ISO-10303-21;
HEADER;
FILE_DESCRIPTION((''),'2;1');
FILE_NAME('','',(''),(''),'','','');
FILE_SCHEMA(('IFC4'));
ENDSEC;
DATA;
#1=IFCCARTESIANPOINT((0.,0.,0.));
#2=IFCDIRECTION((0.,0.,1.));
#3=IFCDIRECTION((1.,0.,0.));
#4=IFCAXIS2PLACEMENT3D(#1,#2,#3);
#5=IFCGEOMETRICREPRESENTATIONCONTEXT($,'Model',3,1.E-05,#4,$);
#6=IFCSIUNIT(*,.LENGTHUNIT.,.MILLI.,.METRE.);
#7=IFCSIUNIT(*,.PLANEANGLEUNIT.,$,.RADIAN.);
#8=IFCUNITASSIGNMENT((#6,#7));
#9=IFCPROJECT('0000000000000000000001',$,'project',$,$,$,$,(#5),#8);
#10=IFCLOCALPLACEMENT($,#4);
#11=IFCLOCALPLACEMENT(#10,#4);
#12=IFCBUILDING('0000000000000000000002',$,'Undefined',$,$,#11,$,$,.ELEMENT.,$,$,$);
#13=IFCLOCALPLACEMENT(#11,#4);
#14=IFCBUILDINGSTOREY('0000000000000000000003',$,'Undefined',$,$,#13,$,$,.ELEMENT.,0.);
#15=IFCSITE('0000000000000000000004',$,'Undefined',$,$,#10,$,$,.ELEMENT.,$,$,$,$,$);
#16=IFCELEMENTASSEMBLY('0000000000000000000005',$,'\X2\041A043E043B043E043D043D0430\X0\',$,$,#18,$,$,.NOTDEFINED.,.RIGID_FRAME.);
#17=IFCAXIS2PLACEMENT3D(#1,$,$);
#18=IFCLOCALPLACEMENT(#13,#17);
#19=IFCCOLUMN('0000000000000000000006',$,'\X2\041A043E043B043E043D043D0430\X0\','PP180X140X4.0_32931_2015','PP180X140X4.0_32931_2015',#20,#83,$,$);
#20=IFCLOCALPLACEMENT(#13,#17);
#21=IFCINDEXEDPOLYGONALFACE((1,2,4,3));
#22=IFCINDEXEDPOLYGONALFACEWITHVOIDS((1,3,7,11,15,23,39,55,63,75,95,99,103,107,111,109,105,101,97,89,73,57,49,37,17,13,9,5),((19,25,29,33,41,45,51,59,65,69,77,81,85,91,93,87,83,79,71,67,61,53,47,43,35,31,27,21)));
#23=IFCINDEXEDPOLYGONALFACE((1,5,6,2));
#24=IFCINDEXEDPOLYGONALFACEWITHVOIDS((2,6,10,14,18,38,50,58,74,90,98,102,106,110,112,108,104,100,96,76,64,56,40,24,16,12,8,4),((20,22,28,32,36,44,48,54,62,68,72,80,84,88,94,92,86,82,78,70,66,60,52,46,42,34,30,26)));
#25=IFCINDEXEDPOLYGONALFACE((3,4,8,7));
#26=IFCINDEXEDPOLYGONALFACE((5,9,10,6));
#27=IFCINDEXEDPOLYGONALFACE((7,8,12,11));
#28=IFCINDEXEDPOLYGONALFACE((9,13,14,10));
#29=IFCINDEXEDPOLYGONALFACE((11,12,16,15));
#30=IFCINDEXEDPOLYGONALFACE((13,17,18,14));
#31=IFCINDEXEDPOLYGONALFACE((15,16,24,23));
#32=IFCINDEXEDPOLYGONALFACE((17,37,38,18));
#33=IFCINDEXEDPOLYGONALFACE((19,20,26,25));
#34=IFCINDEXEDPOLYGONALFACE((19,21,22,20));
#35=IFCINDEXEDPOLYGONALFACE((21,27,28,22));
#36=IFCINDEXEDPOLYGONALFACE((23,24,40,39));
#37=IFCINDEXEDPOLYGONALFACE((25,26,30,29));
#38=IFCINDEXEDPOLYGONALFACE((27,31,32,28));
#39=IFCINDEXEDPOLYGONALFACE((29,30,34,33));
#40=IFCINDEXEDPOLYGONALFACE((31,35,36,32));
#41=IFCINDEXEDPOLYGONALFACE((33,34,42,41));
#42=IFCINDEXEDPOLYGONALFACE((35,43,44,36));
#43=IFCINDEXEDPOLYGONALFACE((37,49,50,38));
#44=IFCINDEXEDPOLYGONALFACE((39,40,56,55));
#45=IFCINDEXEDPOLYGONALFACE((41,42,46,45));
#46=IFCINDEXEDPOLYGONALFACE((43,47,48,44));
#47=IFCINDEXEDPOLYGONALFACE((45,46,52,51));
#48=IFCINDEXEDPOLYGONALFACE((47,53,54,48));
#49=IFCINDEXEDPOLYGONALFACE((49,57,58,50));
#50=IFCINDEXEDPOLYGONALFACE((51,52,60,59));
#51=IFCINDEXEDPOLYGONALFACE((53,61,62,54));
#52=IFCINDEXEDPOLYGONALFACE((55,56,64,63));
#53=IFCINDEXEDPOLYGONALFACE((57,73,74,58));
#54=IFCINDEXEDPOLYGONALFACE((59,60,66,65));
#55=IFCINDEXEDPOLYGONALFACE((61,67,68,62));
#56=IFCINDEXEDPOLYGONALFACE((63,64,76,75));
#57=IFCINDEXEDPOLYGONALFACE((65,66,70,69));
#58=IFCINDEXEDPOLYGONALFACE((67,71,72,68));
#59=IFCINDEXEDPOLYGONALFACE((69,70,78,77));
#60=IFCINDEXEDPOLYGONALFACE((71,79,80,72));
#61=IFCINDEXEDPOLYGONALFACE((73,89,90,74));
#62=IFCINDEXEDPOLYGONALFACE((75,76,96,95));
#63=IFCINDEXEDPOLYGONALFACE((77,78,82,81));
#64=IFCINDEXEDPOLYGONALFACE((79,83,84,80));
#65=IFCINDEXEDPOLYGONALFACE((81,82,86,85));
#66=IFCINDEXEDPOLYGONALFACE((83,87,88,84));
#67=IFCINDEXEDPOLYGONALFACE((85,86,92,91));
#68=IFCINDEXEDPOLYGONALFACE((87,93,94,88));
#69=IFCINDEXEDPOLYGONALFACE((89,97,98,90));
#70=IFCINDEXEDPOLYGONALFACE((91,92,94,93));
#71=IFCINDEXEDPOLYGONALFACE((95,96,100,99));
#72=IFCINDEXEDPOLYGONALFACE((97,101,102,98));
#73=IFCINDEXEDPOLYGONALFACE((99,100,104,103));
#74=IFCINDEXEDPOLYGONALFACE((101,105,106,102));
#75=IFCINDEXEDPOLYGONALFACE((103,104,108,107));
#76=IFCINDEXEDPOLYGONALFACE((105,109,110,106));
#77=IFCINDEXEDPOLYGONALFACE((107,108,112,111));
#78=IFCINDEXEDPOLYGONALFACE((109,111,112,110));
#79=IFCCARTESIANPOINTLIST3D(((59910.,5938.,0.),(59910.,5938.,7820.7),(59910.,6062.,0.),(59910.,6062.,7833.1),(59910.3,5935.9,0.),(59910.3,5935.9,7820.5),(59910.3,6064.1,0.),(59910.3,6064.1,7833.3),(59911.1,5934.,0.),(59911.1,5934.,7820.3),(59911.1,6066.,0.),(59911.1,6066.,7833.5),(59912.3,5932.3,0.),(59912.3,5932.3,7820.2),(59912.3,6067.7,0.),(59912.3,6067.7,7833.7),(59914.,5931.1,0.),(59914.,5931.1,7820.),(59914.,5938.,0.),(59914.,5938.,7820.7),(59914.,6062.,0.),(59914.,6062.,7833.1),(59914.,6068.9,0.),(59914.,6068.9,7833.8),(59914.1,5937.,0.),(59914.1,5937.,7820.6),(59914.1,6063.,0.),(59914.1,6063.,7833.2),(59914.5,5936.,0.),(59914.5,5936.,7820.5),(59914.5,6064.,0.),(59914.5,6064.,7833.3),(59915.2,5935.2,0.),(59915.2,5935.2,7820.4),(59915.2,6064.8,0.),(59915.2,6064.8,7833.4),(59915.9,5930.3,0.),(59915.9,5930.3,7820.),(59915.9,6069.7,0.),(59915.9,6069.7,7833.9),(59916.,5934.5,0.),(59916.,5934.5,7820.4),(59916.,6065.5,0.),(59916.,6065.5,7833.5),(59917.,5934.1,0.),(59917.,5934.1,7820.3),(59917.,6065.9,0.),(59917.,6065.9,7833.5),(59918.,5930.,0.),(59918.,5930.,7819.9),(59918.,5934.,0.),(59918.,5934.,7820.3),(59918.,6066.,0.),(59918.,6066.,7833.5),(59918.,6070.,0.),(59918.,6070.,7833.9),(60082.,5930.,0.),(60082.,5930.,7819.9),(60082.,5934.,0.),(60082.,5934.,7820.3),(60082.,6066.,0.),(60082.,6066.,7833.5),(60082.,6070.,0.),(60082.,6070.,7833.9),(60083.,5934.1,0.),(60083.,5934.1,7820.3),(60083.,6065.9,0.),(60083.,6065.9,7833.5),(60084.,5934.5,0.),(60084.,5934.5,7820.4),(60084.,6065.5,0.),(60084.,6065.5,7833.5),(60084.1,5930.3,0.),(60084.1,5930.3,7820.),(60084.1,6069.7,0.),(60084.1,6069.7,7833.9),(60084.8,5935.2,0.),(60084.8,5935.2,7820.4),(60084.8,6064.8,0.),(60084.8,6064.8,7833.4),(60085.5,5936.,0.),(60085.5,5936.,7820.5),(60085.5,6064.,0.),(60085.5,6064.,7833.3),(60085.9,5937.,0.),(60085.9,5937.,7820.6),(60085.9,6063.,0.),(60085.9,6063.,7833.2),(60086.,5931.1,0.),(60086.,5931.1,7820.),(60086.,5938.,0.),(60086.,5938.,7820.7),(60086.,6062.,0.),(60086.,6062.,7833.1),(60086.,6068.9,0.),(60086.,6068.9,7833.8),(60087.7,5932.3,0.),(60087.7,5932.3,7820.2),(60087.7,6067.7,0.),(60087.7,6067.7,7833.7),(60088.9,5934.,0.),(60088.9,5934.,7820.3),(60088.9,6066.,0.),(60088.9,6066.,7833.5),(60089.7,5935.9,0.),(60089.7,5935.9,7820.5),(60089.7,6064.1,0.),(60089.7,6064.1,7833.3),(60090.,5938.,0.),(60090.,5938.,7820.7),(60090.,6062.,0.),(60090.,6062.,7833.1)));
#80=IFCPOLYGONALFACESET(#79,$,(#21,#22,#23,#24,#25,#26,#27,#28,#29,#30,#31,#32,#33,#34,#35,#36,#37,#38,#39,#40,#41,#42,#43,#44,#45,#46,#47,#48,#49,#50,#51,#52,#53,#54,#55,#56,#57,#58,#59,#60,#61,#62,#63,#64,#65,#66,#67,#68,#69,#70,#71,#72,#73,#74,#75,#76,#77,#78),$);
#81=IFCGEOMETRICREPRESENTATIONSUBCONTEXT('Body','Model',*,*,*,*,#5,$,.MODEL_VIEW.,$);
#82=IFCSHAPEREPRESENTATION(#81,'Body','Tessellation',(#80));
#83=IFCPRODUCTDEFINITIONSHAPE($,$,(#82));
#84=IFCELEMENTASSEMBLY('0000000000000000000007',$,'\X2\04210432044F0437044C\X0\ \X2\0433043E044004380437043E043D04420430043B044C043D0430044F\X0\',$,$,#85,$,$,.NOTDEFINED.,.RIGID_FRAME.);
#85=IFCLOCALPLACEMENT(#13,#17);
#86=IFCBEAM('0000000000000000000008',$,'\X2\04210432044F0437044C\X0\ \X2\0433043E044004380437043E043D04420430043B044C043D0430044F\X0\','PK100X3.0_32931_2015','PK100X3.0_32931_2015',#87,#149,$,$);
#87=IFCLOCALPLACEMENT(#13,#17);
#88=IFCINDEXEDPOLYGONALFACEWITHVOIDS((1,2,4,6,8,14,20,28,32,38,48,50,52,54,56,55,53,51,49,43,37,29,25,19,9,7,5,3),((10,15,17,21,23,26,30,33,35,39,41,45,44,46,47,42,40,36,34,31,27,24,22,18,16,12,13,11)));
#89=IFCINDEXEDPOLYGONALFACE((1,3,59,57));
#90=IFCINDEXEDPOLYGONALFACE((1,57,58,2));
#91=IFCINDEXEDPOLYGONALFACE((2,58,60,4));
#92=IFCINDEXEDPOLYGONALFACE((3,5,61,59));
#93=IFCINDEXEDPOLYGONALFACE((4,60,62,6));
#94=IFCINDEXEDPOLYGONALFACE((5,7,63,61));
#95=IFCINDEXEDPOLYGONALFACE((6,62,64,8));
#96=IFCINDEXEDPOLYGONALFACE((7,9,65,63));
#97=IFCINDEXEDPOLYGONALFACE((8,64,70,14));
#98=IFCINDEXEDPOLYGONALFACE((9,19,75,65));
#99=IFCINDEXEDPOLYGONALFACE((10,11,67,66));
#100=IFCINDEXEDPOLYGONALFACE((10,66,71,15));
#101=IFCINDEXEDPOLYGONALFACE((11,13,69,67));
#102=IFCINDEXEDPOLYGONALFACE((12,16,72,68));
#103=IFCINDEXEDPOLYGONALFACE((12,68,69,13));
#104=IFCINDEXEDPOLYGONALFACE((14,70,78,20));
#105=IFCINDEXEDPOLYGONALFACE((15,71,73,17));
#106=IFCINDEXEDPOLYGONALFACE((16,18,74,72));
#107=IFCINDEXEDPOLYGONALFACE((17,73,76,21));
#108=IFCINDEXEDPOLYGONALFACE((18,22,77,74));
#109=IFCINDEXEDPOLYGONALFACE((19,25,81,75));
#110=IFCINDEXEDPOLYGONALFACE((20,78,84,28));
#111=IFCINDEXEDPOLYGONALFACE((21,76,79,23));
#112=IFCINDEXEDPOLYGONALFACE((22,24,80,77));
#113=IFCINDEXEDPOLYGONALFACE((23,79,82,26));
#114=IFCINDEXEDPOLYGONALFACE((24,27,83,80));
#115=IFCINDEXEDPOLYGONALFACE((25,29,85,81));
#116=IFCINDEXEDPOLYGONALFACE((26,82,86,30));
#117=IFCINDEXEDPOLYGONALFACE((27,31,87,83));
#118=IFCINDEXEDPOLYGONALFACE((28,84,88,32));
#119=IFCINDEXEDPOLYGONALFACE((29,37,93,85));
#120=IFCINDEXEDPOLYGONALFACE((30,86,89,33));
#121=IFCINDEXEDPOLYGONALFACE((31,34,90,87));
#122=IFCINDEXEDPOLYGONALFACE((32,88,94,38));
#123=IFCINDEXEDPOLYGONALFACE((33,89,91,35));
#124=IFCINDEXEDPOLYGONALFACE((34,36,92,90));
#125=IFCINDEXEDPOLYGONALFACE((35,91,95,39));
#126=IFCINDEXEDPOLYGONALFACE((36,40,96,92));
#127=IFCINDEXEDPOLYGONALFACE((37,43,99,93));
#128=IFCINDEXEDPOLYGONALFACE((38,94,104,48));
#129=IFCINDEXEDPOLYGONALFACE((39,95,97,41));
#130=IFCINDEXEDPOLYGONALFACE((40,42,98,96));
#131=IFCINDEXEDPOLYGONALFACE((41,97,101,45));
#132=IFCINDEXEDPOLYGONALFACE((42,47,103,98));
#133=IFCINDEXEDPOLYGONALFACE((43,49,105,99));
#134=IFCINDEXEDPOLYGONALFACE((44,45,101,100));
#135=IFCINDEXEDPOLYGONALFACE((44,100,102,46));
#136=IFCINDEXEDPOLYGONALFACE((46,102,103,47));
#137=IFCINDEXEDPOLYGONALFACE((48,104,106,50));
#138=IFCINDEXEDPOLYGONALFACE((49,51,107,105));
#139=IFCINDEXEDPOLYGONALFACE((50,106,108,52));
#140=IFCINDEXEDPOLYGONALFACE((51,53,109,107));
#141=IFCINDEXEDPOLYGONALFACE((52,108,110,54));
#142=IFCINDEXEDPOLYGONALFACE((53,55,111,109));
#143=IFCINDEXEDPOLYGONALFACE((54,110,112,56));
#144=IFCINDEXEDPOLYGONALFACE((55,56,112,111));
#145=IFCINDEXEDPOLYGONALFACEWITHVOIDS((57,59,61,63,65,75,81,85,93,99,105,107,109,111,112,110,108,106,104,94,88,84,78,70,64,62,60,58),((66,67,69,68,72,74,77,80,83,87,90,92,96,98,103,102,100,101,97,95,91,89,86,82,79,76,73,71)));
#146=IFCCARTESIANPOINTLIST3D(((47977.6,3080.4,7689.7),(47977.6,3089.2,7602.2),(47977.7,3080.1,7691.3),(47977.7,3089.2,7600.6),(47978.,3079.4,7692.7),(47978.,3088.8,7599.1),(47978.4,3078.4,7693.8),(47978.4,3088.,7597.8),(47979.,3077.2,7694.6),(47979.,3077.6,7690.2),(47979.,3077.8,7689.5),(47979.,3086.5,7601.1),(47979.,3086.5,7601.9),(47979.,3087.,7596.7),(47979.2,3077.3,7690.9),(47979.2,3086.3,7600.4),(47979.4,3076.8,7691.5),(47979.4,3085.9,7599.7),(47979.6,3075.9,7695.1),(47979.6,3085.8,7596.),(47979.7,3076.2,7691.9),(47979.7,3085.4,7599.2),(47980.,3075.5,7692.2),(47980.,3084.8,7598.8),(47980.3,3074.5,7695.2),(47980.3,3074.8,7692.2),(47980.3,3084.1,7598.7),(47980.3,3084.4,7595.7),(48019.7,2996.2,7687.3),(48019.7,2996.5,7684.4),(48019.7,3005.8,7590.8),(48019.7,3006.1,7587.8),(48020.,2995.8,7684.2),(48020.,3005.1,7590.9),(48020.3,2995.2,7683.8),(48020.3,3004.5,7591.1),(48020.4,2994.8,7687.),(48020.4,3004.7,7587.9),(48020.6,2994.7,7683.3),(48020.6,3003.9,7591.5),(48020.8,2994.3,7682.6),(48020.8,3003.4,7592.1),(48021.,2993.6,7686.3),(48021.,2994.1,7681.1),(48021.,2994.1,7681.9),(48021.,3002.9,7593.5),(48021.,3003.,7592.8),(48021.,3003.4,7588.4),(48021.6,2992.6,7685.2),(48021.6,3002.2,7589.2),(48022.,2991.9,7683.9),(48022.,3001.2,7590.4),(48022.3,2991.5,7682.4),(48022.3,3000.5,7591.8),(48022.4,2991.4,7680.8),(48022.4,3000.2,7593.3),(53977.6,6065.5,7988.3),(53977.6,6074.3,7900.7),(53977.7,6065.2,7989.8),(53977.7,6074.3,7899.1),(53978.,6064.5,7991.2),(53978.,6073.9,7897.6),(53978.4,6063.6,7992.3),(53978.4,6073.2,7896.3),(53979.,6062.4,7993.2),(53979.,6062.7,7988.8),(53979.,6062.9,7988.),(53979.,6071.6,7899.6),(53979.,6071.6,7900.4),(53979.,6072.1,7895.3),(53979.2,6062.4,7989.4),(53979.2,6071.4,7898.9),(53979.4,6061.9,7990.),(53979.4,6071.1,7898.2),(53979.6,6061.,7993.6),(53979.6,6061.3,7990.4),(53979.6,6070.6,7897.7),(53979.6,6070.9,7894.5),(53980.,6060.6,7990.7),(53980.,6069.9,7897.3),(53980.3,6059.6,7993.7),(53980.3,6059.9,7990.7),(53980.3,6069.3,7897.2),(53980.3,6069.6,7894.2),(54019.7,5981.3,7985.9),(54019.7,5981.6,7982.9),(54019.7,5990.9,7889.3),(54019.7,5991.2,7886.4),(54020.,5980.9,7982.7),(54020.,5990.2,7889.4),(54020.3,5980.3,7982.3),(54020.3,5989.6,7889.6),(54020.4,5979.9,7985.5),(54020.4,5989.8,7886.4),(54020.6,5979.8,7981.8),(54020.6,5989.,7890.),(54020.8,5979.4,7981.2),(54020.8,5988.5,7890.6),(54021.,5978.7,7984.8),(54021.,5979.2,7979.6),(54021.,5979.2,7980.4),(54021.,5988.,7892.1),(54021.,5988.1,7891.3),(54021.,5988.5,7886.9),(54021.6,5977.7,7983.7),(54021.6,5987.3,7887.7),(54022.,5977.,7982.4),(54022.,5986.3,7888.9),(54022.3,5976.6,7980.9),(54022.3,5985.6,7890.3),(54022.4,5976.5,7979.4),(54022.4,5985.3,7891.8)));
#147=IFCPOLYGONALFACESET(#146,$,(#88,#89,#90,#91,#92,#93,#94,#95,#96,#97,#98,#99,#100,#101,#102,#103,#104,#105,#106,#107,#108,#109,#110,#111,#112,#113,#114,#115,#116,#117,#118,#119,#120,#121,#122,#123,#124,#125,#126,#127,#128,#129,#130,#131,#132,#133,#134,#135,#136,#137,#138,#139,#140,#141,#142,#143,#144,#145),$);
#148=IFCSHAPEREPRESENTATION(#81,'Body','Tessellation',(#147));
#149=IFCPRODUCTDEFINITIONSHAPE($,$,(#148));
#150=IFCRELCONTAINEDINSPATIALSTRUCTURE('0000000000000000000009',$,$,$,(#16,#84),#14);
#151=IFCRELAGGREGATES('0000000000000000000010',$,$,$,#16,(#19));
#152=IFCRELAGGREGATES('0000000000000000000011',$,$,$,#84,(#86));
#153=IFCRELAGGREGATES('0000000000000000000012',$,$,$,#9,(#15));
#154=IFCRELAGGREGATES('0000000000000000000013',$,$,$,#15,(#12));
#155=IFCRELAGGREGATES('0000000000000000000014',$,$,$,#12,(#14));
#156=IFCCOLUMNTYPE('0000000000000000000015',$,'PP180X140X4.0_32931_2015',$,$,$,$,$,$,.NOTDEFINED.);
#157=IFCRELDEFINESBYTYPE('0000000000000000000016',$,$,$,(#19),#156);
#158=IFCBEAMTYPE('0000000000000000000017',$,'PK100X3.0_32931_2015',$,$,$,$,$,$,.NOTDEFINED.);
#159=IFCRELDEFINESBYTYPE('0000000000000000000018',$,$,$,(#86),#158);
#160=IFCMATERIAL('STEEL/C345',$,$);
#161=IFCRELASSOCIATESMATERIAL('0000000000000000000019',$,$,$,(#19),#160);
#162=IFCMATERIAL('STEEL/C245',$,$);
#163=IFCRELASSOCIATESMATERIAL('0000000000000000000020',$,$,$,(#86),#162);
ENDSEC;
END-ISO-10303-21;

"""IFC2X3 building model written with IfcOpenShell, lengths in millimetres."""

from ifc_helpers import new_model, si_unit, frame, origin_with_axes, origin_2d_with_axis, place, context, subcontext, project, spatial, hollow_rectangle, extrude, clip, halfspace, material, type_object, element, aggregate, save


model = new_model("IFC2X3")

# Units and contexts
model_context = context("Model", 3, precision=1e-05, world=origin_with_axes())
body_context = subcontext(model_context, "Body", "Model", "MODEL_VIEW")
ifc_project = project(units=[si_unit("LENGTHUNIT", "METRE", prefix="MILLI"), si_unit("PLANEANGLEUNIT", "RADIAN")], contexts=[model_context])

# Site, building, storey
site_placement = place(None, origin_with_axes())
site = spatial("IfcSite", under=ifc_project, at=site_placement, Name="Undefined", CompositionType="ELEMENT")
building_placement = place(site_placement, origin_with_axes())
building = spatial("IfcBuilding", under=site, at=building_placement, Name="Undefined", CompositionType="ELEMENT")
storey_placement = place(building_placement, origin_with_axes())
storey = spatial("IfcBuildingStorey", under=building, at=storey_placement, Name="Undefined", CompositionType="ELEMENT", Elevation=0.0)

# Element assembly, column
assembly_1_placement = place(storey_placement, origin_with_axes())
assembly_1 = element("IfcElementAssembly", 1, at=assembly_1_placement, inside=storey, Name="Колонна", AssemblyPlace="NOTDEFINED", PredefinedType="RIGID_FRAME")
ifc_material_1 = material(Name="STEEL/C345")
column_type = type_object("IfcColumnType", Name="PP180X140X4.0_32931_2015", PredefinedType="NOTDEFINED")
column_placement = place(assembly_1_placement, frame((60000.0, 6000.0, 0.0), z_axis=(0.0, 0.0, 1.0), x_axis=(1.0, 0.0, 0.0)))
column = element("IfcColumn", 2, at=column_placement, type_object=column_type, material=ifc_material_1, Name="Колонна", Description="PP180X140X4.0_32931_2015", ObjectType="PP180X140X4.0_32931_2015", context=body_context, shape_type="Clipping", body=[
    clip(extrude(hollow_rectangle(XDim=140.0, YDim=180.0, WallThickness=4.0, InnerFilletRadius=4.0, OuterFilletRadius=8.0, at=origin_2d_with_axis()), frame((0.0, 0.0, 7834.0), z_axis=(0.0, 0.0, -1.0), x_axis=(0.0, 1.0, 0.0)), (0.0, 0.0, 1.0), 7834.0), halfspace(frame((0.0, -165.8, 7810.3), z_axis=(0.0, 0.099504, -0.995037), x_axis=(-1.0, 0.0, 0.0)), True)),
])
aggregate(assembly_1, [column])

# Element assembly, beam
ifc_material_2 = material(Name="STEEL/C245")
beam_type_1 = type_object("IfcBeamType", Name="PK100X3.0_32931_2015", PredefinedType="NOTDEFINED")
assembly_2_placement = place(storey_placement, origin_with_axes())
assembly_2 = element("IfcElementAssembly", 3, at=assembly_2_placement, inside=storey, Name="Связь горизонтальная", AssemblyPlace="NOTDEFINED", PredefinedType="RIGID_FRAME")
beam_1_placement = place(assembly_2_placement, frame((54000.0, 6025.4, 7940.0), z_axis=(0.0, -0.099504, 0.995037), x_axis=(-0.894427, -0.444994, -0.044499)))
beam_1 = element("IfcBeam", 4, at=beam_1_placement, type_object=beam_type_1, material=ifc_material_2, Name="Связь горизонтальная", Description="PK100X3.0_32931_2015", ObjectType="PK100X3.0_32931_2015", context=body_context, shape_type="SweptSolid", body=[
    extrude(hollow_rectangle(XDim=100.0, YDim=100.0, WallThickness=3.0, InnerFilletRadius=3.0, OuterFilletRadius=6.0, at=origin_2d_with_axis()), frame((6708.2, 0.0, 0.0), z_axis=(-1.0, 0.0, 0.0), x_axis=(0.0, -1.0, 0.0)), (0.0, 0.0, 1.0), 6708.2),
])
aggregate(assembly_2, [beam_1])

save(model, "model.ifc")
